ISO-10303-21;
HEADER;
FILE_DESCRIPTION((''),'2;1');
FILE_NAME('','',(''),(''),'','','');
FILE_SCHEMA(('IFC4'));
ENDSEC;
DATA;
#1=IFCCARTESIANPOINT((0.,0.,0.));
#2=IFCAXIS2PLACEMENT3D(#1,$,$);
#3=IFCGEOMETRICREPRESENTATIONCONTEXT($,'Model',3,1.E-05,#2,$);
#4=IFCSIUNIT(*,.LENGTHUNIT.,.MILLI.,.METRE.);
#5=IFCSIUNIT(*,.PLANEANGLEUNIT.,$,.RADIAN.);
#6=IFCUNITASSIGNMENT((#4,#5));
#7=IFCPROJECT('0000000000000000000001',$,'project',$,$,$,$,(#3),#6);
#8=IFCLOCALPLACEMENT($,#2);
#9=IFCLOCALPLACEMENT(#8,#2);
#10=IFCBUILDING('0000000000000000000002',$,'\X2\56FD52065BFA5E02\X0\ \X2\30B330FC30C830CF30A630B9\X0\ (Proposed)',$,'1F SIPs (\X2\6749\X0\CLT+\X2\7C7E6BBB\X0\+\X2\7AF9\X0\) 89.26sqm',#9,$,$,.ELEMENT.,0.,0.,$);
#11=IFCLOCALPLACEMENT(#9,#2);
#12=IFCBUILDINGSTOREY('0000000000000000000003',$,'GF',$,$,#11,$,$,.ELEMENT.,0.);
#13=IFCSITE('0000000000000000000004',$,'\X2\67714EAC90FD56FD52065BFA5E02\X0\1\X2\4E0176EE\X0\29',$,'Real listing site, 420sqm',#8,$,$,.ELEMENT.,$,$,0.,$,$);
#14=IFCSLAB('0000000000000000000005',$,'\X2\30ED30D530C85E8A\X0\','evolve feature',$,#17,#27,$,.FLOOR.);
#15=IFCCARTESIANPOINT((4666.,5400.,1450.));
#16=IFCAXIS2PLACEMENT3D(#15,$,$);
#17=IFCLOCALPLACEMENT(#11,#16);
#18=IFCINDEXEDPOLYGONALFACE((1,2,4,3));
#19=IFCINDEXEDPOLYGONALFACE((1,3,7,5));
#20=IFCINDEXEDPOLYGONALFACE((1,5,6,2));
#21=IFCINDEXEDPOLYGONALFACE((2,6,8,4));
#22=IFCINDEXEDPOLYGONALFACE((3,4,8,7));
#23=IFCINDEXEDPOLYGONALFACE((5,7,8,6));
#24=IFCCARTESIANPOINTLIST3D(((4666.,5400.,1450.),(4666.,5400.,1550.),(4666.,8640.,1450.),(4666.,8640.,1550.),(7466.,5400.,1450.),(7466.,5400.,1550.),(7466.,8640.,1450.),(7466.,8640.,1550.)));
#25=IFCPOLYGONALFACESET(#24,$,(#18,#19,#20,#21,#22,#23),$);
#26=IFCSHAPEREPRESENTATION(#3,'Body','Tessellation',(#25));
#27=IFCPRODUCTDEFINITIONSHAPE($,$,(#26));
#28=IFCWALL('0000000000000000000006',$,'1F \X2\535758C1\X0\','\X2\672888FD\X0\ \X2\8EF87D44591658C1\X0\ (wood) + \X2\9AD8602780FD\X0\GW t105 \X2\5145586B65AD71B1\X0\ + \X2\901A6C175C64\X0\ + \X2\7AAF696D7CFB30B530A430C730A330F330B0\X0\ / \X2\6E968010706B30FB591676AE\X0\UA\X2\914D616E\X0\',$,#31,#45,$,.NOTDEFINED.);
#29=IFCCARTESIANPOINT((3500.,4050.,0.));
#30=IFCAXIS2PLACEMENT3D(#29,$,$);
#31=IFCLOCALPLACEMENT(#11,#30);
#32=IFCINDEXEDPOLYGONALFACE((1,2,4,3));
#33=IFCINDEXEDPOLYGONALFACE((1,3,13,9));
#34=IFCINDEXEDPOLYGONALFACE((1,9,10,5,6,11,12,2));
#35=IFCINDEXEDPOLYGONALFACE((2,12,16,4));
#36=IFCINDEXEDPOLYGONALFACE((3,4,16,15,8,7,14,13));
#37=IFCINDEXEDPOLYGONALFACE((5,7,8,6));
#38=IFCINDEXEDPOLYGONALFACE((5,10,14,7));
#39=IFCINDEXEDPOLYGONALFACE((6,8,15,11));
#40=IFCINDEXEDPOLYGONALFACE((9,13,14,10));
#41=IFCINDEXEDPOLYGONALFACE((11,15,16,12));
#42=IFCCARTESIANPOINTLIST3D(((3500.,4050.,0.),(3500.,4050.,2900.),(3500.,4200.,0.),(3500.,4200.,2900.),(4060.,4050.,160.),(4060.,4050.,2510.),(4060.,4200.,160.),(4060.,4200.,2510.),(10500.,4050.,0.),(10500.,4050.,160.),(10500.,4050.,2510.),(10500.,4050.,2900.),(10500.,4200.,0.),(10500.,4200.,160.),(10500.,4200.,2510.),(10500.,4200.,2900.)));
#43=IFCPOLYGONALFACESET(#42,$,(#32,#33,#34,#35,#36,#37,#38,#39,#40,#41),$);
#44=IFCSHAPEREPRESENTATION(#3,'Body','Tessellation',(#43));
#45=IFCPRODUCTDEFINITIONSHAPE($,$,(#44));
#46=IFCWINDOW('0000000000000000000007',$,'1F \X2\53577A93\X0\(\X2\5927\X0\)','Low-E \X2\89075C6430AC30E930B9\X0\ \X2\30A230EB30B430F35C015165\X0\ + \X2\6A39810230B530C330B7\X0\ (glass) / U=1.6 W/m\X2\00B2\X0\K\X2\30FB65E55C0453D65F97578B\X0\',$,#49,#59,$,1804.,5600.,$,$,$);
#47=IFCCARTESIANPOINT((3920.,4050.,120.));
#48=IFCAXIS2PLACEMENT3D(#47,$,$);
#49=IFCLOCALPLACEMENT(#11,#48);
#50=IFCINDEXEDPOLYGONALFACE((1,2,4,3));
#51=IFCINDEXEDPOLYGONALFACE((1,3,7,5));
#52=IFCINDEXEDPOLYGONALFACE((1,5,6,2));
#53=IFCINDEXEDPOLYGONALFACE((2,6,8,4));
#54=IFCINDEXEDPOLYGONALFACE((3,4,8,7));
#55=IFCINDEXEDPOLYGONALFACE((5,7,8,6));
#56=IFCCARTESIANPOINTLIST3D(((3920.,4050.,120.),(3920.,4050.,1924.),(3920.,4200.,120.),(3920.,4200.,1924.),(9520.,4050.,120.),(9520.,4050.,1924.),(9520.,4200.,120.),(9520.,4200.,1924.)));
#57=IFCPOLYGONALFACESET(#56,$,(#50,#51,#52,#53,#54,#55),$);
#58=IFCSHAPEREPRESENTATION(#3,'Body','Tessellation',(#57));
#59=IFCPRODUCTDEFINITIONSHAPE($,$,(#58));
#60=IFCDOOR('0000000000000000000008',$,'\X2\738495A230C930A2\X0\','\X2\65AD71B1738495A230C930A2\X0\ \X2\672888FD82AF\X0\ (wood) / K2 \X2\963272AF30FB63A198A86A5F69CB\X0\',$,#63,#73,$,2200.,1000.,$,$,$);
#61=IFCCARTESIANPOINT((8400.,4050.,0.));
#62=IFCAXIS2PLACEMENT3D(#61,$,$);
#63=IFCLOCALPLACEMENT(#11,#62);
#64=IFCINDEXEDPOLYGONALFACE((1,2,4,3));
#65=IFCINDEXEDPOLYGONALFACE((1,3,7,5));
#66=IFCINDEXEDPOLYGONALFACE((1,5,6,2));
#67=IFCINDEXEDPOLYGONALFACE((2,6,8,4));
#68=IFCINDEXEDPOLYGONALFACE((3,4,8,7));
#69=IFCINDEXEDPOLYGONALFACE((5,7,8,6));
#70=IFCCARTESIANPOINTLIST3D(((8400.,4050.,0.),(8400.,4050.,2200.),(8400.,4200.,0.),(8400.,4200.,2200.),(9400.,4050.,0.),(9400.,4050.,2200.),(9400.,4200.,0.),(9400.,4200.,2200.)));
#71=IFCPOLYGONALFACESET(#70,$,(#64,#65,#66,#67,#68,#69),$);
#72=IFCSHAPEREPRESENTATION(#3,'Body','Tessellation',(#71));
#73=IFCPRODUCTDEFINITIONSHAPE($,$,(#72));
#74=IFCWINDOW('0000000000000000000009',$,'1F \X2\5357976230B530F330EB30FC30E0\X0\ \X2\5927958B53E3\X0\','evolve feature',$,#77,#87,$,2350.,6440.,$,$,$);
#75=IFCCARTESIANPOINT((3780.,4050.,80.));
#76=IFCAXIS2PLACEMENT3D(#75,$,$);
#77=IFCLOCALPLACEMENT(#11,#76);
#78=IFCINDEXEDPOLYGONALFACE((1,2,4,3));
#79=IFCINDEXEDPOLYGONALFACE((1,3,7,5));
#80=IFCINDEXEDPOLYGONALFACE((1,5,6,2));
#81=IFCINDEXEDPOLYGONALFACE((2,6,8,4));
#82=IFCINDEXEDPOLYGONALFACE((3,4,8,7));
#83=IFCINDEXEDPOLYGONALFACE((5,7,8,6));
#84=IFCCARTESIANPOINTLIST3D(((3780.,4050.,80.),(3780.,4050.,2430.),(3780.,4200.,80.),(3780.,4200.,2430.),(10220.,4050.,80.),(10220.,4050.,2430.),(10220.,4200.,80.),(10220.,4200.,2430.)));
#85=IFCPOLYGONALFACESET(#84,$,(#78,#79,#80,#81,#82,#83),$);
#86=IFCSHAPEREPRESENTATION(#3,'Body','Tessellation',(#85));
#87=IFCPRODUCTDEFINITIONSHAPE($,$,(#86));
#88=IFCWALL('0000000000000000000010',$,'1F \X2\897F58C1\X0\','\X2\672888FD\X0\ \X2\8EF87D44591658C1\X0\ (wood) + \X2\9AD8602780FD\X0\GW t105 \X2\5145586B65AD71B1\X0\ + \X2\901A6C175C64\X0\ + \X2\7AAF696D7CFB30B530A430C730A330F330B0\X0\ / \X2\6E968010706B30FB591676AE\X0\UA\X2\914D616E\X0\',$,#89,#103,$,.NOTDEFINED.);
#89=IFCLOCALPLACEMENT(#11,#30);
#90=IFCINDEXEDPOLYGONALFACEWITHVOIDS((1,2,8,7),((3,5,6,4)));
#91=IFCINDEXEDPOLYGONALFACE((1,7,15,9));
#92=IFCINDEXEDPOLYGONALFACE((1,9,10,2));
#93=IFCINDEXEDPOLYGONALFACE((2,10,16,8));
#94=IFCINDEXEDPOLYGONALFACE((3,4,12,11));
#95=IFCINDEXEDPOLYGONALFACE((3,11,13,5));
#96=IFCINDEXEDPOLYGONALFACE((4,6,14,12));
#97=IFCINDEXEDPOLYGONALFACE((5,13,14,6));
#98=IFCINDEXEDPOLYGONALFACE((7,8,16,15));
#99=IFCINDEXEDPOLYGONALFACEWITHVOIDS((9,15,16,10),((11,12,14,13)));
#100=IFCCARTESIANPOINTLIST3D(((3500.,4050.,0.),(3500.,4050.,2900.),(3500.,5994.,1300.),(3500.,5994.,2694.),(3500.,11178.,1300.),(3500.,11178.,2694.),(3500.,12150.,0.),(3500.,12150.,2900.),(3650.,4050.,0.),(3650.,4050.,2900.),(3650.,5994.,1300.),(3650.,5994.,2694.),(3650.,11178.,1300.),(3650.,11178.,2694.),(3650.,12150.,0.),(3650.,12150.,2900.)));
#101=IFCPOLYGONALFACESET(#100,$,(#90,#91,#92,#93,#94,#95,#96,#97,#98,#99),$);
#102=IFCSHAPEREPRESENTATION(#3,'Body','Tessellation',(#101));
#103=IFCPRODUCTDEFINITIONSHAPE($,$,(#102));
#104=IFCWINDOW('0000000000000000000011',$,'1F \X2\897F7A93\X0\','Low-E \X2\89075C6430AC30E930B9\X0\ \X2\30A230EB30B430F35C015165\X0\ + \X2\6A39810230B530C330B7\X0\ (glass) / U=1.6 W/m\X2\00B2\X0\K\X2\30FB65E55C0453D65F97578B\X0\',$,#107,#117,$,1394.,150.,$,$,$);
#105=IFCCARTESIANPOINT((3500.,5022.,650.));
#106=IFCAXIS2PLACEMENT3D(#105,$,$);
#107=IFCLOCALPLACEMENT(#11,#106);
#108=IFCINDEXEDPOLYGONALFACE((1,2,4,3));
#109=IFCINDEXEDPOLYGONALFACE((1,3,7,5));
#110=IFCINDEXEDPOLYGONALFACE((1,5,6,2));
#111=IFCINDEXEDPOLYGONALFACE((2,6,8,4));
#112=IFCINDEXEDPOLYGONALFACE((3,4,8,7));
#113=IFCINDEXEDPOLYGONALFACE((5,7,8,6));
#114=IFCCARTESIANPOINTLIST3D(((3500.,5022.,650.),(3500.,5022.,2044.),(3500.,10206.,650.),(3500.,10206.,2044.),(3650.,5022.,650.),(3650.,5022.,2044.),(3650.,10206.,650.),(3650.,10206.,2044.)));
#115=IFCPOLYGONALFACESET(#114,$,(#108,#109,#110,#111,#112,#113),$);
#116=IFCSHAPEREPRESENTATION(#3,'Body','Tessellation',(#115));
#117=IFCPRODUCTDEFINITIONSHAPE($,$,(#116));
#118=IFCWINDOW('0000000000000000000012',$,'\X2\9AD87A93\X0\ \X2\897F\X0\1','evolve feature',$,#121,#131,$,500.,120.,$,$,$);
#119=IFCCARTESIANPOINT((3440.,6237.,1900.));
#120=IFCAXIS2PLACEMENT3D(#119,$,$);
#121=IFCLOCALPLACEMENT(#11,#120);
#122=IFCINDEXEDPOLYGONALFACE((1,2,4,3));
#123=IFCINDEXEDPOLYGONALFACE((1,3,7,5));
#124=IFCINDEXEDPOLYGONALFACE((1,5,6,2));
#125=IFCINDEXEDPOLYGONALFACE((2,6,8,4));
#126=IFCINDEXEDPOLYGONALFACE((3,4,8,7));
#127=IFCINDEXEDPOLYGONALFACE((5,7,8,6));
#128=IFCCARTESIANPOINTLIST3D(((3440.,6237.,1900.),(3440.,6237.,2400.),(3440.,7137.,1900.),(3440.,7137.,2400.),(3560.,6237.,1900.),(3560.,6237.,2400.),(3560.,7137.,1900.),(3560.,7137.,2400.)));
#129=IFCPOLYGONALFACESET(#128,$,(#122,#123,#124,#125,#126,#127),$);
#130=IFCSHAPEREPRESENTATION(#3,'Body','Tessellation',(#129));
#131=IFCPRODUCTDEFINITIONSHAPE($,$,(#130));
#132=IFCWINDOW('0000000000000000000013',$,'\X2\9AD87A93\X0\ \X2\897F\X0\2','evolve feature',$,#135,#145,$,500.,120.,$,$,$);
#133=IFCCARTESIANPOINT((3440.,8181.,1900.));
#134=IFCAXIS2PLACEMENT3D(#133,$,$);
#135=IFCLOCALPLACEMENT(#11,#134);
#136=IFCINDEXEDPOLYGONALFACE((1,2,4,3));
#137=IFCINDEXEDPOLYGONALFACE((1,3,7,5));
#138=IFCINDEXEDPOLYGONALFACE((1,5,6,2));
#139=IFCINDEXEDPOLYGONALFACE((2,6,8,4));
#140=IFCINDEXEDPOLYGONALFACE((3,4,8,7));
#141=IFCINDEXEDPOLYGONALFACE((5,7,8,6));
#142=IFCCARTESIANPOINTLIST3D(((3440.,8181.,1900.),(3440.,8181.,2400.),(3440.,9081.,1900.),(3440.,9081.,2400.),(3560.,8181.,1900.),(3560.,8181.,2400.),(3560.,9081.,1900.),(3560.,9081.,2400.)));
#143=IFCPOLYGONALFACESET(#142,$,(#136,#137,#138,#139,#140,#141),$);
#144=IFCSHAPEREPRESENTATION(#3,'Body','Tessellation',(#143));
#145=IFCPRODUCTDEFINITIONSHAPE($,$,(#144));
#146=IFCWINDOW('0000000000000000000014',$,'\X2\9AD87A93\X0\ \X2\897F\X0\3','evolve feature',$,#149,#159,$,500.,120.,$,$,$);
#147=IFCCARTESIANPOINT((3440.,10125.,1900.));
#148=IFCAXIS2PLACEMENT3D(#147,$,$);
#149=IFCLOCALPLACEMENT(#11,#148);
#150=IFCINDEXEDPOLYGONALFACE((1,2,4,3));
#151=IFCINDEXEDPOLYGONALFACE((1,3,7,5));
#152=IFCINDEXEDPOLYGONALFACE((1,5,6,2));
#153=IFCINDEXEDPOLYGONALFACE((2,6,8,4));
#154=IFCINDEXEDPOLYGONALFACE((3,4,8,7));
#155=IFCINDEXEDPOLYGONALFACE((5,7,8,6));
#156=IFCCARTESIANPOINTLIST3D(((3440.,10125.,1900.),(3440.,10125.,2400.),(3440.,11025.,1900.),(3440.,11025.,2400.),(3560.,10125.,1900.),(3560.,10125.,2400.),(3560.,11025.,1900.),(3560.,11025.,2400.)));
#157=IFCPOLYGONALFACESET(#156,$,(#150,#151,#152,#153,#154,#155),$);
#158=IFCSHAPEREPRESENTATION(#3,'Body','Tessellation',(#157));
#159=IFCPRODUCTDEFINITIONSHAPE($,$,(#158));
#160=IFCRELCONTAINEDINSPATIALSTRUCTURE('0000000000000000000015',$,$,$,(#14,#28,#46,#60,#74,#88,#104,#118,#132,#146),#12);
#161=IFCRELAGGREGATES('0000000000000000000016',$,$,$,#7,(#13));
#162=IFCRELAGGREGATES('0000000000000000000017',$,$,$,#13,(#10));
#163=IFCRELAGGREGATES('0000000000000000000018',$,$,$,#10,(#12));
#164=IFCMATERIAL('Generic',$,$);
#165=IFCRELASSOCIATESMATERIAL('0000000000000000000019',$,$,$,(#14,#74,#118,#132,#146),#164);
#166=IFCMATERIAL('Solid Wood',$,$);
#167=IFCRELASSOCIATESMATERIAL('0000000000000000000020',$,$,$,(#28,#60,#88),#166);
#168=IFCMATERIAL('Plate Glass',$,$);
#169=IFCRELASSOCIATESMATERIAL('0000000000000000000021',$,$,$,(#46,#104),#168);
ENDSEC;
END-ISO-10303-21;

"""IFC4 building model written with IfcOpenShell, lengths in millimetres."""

from ifc_helpers import new_model, si_unit, frame, frame_2d, origin, place, context, project, spatial, rectangle, extrude, material, element, fill, save


model = new_model("IFC4")

# Units and contexts
model_context = context("Model", 3, precision=1e-05, world=origin())
ifc_project = project(units=[si_unit("LENGTHUNIT", "METRE", prefix="MILLI"), si_unit("PLANEANGLEUNIT", "RADIAN")], contexts=[model_context])

# Site, building, storey
site_placement = place(None, origin())
site = spatial("IfcSite", under=ifc_project, at=site_placement, Name="東京都国分寺市1丁目29", ObjectType="Real listing site, 420sqm", CompositionType="ELEMENT", RefElevation=0.0)
building_placement = place(site_placement, origin())
building = spatial("IfcBuilding", under=site, at=building_placement, Name="国分寺市 コートハウス (Proposed)", ObjectType="1F SIPs (杉CLT+籾殻+竹) 89.26sqm", CompositionType="ELEMENT", ElevationOfRefHeight=0.0, ElevationOfTerrain=0.0)
storey_placement = place(building_placement, origin())
storey = spatial("IfcBuildingStorey", under=building, at=storey_placement, Name="GF", CompositionType="ELEMENT", Elevation=0.0)

# Slab
ifc_material_1 = material(Name="Solid Wood")
ifc_material_2 = material(Name="Generic")
slab_1_placement = place(storey_placement, frame((4666.0, 5400.0, 1450.0)))
element("IfcSlab", 1, at=slab_1_placement, inside=storey, material=ifc_material_2, Name="ロフト床", Description="evolve feature", PredefinedType="FLOOR", context=model_context, shape_type="SweptSolid", body=[
    extrude(rectangle(XDim=2800.0, YDim=3240.0, at=frame_2d((1400.0, 1620.0))), frame((4666.0, 5400.0, 1450.0)), (0.0, 0.0, 1.0), 100.0),
])

# Wall, openings, windows, door
wall_1_placement = place(storey_placement, frame((3500.0, 4050.0, 0.0)))
wall_1 = element("IfcWall", 2, at=wall_1_placement, inside=storey, material=ifc_material_1, Name="1F 南壁", Description="木製 軸組外壁 (wood) + 高性能GW t105 充填断熱 + 通気層 + 窯業系サイディング / 準耐火・外皮UA配慮", PredefinedType="NOTDEFINED", context=model_context, shape_type="SweptSolid", body=[
    extrude(rectangle(XDim=7000.0, YDim=150.0, at=frame_2d((3500.0, 75.0))), frame((3500.0, 4050.0, 0.0)), (0.0, 0.0, 1.0), 2900.0),
])
opening_1_placement = place(storey_placement, frame((3920.0, 4050.0, 120.0)))
opening_1 = element("IfcOpeningElement", 3, at=opening_1_placement, cuts=wall_1, PredefinedType="NOTDEFINED", context=model_context, shape_type="SweptSolid", body=[
    extrude(rectangle(XDim=5600.0, YDim=150.0, at=frame_2d((2800.0, 75.0))), frame((3920.0, 4050.0, 120.0)), (0.0, 0.0, 1.0), 1804.0),
])
opening_2_placement = place(storey_placement, frame((8400.0, 4050.0, 0.0)))
opening_2 = element("IfcOpeningElement", 4, at=opening_2_placement, cuts=wall_1, PredefinedType="NOTDEFINED", context=model_context, shape_type="SweptSolid", body=[
    extrude(rectangle(XDim=1000.0, YDim=150.0, at=frame_2d((500.0, 75.0))), frame((8400.0, 4050.0, 0.0)), (0.0, 0.0, 1.0), 2200.0),
])
opening_3_placement = place(storey_placement, frame((3780.0, 4050.0, 80.0)))
opening_3 = element("IfcOpeningElement", 5, at=opening_3_placement, cuts=wall_1, PredefinedType="NOTDEFINED", context=model_context, shape_type="SweptSolid", body=[
    extrude(rectangle(XDim=6440.0, YDim=150.0, at=frame_2d((3220.0, 75.0))), frame((3780.0, 4050.0, 80.0)), (0.0, 0.0, 1.0), 2350.0),
])
ifc_material_3 = material(Name="Plate Glass")
window_1_placement = place(storey_placement, frame((3920.0, 4050.0, 120.0)))
window_1 = element("IfcWindow", 6, at=window_1_placement, inside=storey, material=ifc_material_3, Name="1F 南窓(大)", Description="Low-E 複層ガラス アルゴン封入 + 樹脂サッシ (glass) / U=1.6 W/m²K・日射取得型", OverallHeight=1804.0, OverallWidth=5600.0, context=model_context, shape_type="SweptSolid", body=[
    extrude(rectangle(XDim=5600.0, YDim=150.0, at=frame_2d((2800.0, 75.0))), frame((3920.0, 4050.0, 120.0)), (0.0, 0.0, 1.0), 1804.0),
])
fill(opening_1, window_1)
door_placement = place(storey_placement, frame((8400.0, 4050.0, 0.0)))
door = element("IfcDoor", 7, at=door_placement, inside=storey, material=ifc_material_1, Name="玄関ドア", Description="断熱玄関ドア 木製芯 (wood) / K2 防犯・採風機構", OverallHeight=2200.0, OverallWidth=1000.0, context=model_context, shape_type="SweptSolid", body=[
    extrude(rectangle(XDim=1000.0, YDim=150.0, at=frame_2d((500.0, 75.0))), frame((8400.0, 4050.0, 0.0)), (0.0, 0.0, 1.0), 2200.0),
])
fill(opening_2, door)
window_2_placement = place(storey_placement, frame((3780.0, 4050.0, 80.0)))
window_2 = element("IfcWindow", 8, at=window_2_placement, inside=storey, material=ifc_material_2, Name="1F 南面サンルーム 大開口", Description="evolve feature", OverallHeight=2350.0, OverallWidth=6440.0, context=model_context, shape_type="SweptSolid", body=[
    extrude(rectangle(XDim=6440.0, YDim=150.0, at=frame_2d((3220.0, 75.0))), frame((3780.0, 4050.0, 80.0)), (0.0, 0.0, 1.0), 2350.0),
])
fill(opening_3, window_2)

# Wall, openings, windows
wall_2_placement = place(storey_placement, frame((3500.0, 4050.0, 0.0)))
wall_2 = element("IfcWall", 9, at=wall_2_placement, inside=storey, material=ifc_material_1, Name="1F 西壁", Description="木製 軸組外壁 (wood) + 高性能GW t105 充填断熱 + 通気層 + 窯業系サイディング / 準耐火・外皮UA配慮", PredefinedType="NOTDEFINED", context=model_context, shape_type="SweptSolid", body=[
    extrude(rectangle(XDim=150.0, YDim=8100.0, at=frame_2d((75.0, 4050.0))), frame((3500.0, 4050.0, 0.0)), (0.0, 0.0, 1.0), 2900.0),
])
opening_4_placement = place(storey_placement, frame((3500.0, 5022.0, 650.0)))
opening_4 = element("IfcOpeningElement", 10, at=opening_4_placement, cuts=wall_2, PredefinedType="NOTDEFINED", context=model_context, shape_type="SweptSolid", body=[
    extrude(rectangle(XDim=150.0, YDim=5184.0, at=frame_2d((75.0, 2592.0))), frame((3500.0, 5022.0, 650.0)), (0.0, 0.0, 1.0), 1394.0),
])
opening_5_placement = place(storey_placement, frame((3440.0, 6237.0, 1900.0)))
opening_5 = element("IfcOpeningElement", 11, at=opening_5_placement, cuts=wall_2, PredefinedType="NOTDEFINED", context=model_context, shape_type="SweptSolid", body=[
    extrude(rectangle(XDim=120.0, YDim=900.0, at=frame_2d((60.0, 450.0))), frame((3440.0, 6237.0, 1900.0)), (0.0, 0.0, 1.0), 500.0),
])
opening_6_placement = place(storey_placement, frame((3440.0, 8181.0, 1900.0)))
opening_6 = element("IfcOpeningElement", 12, at=opening_6_placement, cuts=wall_2, PredefinedType="NOTDEFINED", context=model_context, shape_type="SweptSolid", body=[
    extrude(rectangle(XDim=120.0, YDim=900.0, at=frame_2d((60.0, 450.0))), frame((3440.0, 8181.0, 1900.0)), (0.0, 0.0, 1.0), 500.0),
])
opening_7_placement = place(storey_placement, frame((3440.0, 10125.0, 1900.0)))
opening_7 = element("IfcOpeningElement", 13, at=opening_7_placement, cuts=wall_2, PredefinedType="NOTDEFINED", context=model_context, shape_type="SweptSolid", body=[
    extrude(rectangle(XDim=120.0, YDim=900.0, at=frame_2d((60.0, 450.0))), frame((3440.0, 10125.0, 1900.0)), (0.0, 0.0, 1.0), 500.0),
])
window_3_placement = place(storey_placement, frame((3500.0, 5022.0, 650.0)))
window_3 = element("IfcWindow", 14, at=window_3_placement, inside=storey, material=ifc_material_3, Name="1F 西窓", Description="Low-E 複層ガラス アルゴン封入 + 樹脂サッシ (glass) / U=1.6 W/m²K・日射取得型", OverallHeight=1394.0, OverallWidth=150.0, context=model_context, shape_type="SweptSolid", body=[
    extrude(rectangle(XDim=150.0, YDim=5184.0, at=frame_2d((75.0, 2592.0))), frame((3500.0, 5022.0, 650.0)), (0.0, 0.0, 1.0), 1394.0),
])
fill(opening_4, window_3)
window_4_placement = place(storey_placement, frame((3440.0, 6237.0, 1900.0)))
window_4 = element("IfcWindow", 15, at=window_4_placement, inside=storey, material=ifc_material_2, Name="高窓 西1", Description="evolve feature", OverallHeight=500.0, OverallWidth=120.0, context=model_context, shape_type="SweptSolid", body=[
    extrude(rectangle(XDim=120.0, YDim=900.0, at=frame_2d((60.0, 450.0))), frame((3440.0, 6237.0, 1900.0)), (0.0, 0.0, 1.0), 500.0),
])
fill(opening_5, window_4)
window_5_placement = place(storey_placement, frame((3440.0, 8181.0, 1900.0)))
window_5 = element("IfcWindow", 16, at=window_5_placement, inside=storey, material=ifc_material_2, Name="高窓 西2", Description="evolve feature", OverallHeight=500.0, OverallWidth=120.0, context=model_context, shape_type="SweptSolid", body=[
    extrude(rectangle(XDim=120.0, YDim=900.0, at=frame_2d((60.0, 450.0))), frame((3440.0, 8181.0, 1900.0)), (0.0, 0.0, 1.0), 500.0),
])
fill(opening_6, window_5)
window_6_placement = place(storey_placement, frame((3440.0, 10125.0, 1900.0)))
window_6 = element("IfcWindow", 17, at=window_6_placement, inside=storey, material=ifc_material_2, Name="高窓 西3", Description="evolve feature", OverallHeight=500.0, OverallWidth=120.0, context=model_context, shape_type="SweptSolid", body=[
    extrude(rectangle(XDim=120.0, YDim=900.0, at=frame_2d((60.0, 450.0))), frame((3440.0, 10125.0, 1900.0)), (0.0, 0.0, 1.0), 500.0),
])
fill(opening_7, window_6)

save(model, "model.ifc")
